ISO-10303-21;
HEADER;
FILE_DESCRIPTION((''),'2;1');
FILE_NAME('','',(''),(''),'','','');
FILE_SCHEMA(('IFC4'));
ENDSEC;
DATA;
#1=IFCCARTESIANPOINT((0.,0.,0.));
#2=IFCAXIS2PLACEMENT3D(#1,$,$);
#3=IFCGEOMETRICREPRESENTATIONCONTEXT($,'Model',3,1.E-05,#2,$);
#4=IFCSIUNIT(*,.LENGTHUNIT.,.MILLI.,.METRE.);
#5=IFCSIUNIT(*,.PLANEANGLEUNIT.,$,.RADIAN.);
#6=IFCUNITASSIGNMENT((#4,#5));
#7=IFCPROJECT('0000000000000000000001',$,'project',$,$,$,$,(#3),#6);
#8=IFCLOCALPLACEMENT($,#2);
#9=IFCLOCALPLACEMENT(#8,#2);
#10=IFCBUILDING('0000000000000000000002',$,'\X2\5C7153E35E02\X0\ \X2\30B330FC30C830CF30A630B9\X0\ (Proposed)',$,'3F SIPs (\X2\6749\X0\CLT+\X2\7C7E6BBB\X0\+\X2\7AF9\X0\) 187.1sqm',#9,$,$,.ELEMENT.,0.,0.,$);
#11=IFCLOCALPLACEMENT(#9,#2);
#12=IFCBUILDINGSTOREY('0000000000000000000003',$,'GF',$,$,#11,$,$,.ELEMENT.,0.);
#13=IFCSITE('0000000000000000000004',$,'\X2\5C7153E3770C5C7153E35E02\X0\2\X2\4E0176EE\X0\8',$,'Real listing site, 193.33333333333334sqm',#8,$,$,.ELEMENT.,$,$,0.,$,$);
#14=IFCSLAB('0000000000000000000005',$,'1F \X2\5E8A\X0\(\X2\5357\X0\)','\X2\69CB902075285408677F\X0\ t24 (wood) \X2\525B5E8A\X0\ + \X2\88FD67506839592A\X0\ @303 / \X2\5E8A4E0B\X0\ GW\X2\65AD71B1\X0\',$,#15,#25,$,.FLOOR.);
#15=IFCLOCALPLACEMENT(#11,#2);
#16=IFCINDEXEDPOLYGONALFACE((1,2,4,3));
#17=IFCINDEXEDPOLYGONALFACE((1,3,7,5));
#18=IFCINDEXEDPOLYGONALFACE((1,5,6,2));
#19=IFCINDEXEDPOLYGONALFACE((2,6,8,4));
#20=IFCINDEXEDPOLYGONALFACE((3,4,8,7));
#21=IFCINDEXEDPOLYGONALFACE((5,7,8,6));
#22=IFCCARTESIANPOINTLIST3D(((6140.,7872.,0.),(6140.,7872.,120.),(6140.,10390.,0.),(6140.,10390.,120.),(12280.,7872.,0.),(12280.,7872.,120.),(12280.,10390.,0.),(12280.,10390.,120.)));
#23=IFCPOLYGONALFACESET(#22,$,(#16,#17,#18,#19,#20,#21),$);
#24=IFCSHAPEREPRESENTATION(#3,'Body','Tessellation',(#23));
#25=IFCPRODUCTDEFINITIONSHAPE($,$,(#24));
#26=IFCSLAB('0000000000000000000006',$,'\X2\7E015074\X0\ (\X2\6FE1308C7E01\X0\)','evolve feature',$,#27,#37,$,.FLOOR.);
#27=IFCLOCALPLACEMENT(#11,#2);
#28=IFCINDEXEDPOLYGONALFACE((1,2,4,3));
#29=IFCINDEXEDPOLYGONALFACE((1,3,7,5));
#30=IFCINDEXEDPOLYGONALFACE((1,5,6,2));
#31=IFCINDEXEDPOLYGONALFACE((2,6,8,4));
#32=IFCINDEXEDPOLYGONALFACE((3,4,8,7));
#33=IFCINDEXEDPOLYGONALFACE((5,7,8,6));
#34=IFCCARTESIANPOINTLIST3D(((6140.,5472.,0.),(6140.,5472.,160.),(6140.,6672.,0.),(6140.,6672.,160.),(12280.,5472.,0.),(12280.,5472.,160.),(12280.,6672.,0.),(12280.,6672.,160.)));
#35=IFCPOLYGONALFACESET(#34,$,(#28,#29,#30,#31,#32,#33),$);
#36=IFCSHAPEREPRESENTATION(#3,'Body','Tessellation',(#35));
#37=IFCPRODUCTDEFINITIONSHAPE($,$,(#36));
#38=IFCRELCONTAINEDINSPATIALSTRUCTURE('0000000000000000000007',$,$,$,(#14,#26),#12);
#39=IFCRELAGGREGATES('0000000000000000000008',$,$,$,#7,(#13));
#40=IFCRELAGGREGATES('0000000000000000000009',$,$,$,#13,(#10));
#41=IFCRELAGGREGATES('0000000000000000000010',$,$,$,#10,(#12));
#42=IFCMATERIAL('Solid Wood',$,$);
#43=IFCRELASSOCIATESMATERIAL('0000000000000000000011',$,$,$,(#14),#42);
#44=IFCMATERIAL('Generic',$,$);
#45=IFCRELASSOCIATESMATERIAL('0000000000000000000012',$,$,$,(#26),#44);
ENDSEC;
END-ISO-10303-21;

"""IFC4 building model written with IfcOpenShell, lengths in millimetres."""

from ifc_helpers import new_model, si_unit, frame, frame_2d, origin, place, context, project, spatial, rectangle, extrude, material, element, save


model = new_model("IFC4")

# Units and contexts
model_context = context("Model", 3, precision=1e-05, world=origin())
ifc_project = project(units=[si_unit("LENGTHUNIT", "METRE", prefix="MILLI"), si_unit("PLANEANGLEUNIT", "RADIAN")], contexts=[model_context])

# Site, building, storey
site_placement = place(None, origin())
site = spatial("IfcSite", under=ifc_project, at=site_placement, Name="山口県山口市2丁目8", ObjectType="Real listing site, 193.33333333333334sqm", CompositionType="ELEMENT", RefElevation=0.0)
building_placement = place(site_placement, origin())
building = spatial("IfcBuilding", under=site, at=building_placement, Name="山口市 コートハウス (Proposed)", ObjectType="3F SIPs (杉CLT+籾殻+竹) 187.1sqm", CompositionType="ELEMENT", ElevationOfRefHeight=0.0, ElevationOfTerrain=0.0)
storey_placement = place(building_placement, origin())
storey = spatial("IfcBuildingStorey", under=building, at=storey_placement, Name="GF", CompositionType="ELEMENT", Elevation=0.0)

# Slabs
ifc_material_1 = material(Name="Solid Wood")
slab_1_placement = place(storey_placement, frame((3070.0, 3936.0, 0.0)))
element("IfcSlab", 1, at=slab_1_placement, inside=storey, material=ifc_material_1, Name="1F 床(南)", Description="構造用合板 t24 (wood) 剛床 + 製材根太 @303 / 床下 GW断熱", PredefinedType="FLOOR", context=model_context, shape_type="SweptSolid", body=[
    extrude(rectangle(XDim=6140.0, YDim=2518.0, at=frame_2d((3070.0, 1259.0))), frame((3070.0, 3936.0, 0.0)), (0.0, 0.0, 1.0), 120.0),
])
ifc_material_2 = material(Name="Generic")
slab_2_placement = place(storey_placement, frame((3070.0, 2736.0, 0.0)))
element("IfcSlab", 2, at=slab_2_placement, inside=storey, material=ifc_material_2, Name="縁側 (濡れ縁)", Description="evolve feature", PredefinedType="FLOOR", context=model_context, shape_type="SweptSolid", body=[
    extrude(rectangle(XDim=6140.0, YDim=1200.0, at=frame_2d((3070.0, 600.0))), frame((3070.0, 2736.0, 0.0)), (0.0, 0.0, 1.0), 160.0),
])

save(model, "model.ifc")
